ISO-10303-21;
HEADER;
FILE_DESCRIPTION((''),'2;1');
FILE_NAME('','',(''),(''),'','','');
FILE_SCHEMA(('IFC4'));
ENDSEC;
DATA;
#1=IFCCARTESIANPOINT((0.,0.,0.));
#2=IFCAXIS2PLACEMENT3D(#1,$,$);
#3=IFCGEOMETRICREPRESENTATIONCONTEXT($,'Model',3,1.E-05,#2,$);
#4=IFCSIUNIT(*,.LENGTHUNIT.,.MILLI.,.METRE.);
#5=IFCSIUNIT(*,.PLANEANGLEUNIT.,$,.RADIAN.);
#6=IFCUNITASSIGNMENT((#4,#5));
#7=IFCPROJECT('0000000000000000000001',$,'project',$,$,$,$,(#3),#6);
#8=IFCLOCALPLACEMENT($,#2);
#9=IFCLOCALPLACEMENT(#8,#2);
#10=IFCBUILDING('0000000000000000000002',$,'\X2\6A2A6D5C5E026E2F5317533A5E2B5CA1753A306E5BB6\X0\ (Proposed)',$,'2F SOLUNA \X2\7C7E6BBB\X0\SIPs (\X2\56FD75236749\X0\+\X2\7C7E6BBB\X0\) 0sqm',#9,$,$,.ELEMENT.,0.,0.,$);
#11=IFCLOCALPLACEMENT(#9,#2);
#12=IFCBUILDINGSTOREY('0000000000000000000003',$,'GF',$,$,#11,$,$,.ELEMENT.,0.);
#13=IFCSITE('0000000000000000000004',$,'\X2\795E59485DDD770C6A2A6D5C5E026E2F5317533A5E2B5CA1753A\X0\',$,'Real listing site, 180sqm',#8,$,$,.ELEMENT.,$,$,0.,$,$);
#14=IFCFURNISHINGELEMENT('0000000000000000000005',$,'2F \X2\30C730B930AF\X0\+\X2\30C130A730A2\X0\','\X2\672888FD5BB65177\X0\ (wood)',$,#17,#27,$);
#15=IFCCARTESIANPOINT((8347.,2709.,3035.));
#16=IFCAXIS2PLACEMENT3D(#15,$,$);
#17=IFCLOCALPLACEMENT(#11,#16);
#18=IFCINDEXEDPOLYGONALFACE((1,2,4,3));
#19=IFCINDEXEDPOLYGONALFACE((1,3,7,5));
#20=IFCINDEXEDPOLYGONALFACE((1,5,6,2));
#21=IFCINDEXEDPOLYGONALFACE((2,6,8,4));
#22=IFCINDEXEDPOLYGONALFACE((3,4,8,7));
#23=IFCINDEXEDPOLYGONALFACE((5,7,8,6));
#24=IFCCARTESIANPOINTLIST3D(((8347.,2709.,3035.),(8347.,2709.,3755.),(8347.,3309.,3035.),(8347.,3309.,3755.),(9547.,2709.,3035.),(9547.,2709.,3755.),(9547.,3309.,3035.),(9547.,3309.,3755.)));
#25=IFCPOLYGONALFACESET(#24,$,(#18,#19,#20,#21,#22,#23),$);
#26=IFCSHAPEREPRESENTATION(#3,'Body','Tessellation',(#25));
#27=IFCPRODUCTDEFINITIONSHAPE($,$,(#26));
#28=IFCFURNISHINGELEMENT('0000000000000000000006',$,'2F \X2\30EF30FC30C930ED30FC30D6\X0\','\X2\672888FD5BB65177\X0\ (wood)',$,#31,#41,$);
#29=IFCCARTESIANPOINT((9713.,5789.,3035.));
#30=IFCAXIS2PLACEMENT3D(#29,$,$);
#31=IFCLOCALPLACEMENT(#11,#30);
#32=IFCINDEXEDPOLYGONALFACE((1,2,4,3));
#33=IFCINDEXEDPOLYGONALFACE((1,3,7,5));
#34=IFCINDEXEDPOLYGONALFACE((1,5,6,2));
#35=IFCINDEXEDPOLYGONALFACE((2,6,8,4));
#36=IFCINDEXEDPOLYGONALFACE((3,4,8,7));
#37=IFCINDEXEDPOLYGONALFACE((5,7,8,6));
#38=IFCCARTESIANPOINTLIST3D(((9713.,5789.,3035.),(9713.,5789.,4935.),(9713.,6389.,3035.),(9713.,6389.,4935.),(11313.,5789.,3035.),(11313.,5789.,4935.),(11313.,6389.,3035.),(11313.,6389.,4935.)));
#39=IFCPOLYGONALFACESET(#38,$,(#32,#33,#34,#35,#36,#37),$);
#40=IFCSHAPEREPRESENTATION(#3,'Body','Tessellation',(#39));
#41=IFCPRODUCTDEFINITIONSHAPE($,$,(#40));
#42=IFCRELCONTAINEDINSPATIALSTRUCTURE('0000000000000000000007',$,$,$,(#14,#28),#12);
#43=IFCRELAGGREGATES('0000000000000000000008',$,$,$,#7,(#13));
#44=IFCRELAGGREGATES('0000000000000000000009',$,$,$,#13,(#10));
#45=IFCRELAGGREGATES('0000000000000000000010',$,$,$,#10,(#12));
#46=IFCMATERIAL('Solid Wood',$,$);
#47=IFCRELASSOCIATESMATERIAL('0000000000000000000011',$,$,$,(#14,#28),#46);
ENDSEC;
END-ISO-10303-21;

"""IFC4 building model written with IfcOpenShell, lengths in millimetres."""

from ifc_helpers import new_model, si_unit, frame, frame_2d, origin, place, context, project, spatial, rectangle, extrude, material, element, save


model = new_model("IFC4")

# Units and contexts
model_context = context("Model", 3, precision=1e-05, world=origin())
ifc_project = project(units=[si_unit("LENGTHUNIT", "METRE", prefix="MILLI"), si_unit("PLANEANGLEUNIT", "RADIAN")], contexts=[model_context])

# Site, building, storey
site_placement = place(None, origin())
site = spatial("IfcSite", under=ifc_project, at=site_placement, Name="神奈川県横浜市港北区師岡町", ObjectType="Real listing site, 180sqm", CompositionType="ELEMENT", RefElevation=0.0)
building_placement = place(site_placement, origin())
building = spatial("IfcBuilding", under=site, at=building_placement, Name="横浜市港北区師岡町の家 (Proposed)", ObjectType="2F SOLUNA 籾殻SIPs (国産杉+籾殻) 0sqm", CompositionType="ELEMENT", ElevationOfRefHeight=0.0, ElevationOfTerrain=0.0)
storey_placement = place(building_placement, origin())
storey = spatial("IfcBuildingStorey", under=building, at=storey_placement, Name="GF", CompositionType="ELEMENT", Elevation=0.0)

# Shared definitions
ifc_material_1 = material(Name="Solid Wood")

# Furnishing elements
furnishing_1_placement = place(storey_placement, frame((8347.0, 2709.0, 3035.0)))
element("IfcFurnishingElement", 1, at=furnishing_1_placement, inside=storey, material=ifc_material_1, Name="2F デスク+チェア", Description="木製家具 (wood)", context=model_context, shape_type="SweptSolid", body=[
    extrude(rectangle(XDim=1200.0, YDim=600.0, at=frame_2d((600.0, 300.0))), frame((8347.0, 2709.0, 3035.0)), (0.0, 0.0, 1.0), 720.0),
])
furnishing_2_placement = place(storey_placement, frame((9713.0, 5789.0, 3035.0)))
element("IfcFurnishingElement", 2, at=furnishing_2_placement, inside=storey, material=ifc_material_1, Name="2F ワードローブ", Description="木製家具 (wood)", context=model_context, shape_type="SweptSolid", body=[
    extrude(rectangle(XDim=1600.0, YDim=600.0, at=frame_2d((800.0, 300.0))), frame((9713.0, 5789.0, 3035.0)), (0.0, 0.0, 1.0), 1900.0),
])

save(model, "model.ifc")
